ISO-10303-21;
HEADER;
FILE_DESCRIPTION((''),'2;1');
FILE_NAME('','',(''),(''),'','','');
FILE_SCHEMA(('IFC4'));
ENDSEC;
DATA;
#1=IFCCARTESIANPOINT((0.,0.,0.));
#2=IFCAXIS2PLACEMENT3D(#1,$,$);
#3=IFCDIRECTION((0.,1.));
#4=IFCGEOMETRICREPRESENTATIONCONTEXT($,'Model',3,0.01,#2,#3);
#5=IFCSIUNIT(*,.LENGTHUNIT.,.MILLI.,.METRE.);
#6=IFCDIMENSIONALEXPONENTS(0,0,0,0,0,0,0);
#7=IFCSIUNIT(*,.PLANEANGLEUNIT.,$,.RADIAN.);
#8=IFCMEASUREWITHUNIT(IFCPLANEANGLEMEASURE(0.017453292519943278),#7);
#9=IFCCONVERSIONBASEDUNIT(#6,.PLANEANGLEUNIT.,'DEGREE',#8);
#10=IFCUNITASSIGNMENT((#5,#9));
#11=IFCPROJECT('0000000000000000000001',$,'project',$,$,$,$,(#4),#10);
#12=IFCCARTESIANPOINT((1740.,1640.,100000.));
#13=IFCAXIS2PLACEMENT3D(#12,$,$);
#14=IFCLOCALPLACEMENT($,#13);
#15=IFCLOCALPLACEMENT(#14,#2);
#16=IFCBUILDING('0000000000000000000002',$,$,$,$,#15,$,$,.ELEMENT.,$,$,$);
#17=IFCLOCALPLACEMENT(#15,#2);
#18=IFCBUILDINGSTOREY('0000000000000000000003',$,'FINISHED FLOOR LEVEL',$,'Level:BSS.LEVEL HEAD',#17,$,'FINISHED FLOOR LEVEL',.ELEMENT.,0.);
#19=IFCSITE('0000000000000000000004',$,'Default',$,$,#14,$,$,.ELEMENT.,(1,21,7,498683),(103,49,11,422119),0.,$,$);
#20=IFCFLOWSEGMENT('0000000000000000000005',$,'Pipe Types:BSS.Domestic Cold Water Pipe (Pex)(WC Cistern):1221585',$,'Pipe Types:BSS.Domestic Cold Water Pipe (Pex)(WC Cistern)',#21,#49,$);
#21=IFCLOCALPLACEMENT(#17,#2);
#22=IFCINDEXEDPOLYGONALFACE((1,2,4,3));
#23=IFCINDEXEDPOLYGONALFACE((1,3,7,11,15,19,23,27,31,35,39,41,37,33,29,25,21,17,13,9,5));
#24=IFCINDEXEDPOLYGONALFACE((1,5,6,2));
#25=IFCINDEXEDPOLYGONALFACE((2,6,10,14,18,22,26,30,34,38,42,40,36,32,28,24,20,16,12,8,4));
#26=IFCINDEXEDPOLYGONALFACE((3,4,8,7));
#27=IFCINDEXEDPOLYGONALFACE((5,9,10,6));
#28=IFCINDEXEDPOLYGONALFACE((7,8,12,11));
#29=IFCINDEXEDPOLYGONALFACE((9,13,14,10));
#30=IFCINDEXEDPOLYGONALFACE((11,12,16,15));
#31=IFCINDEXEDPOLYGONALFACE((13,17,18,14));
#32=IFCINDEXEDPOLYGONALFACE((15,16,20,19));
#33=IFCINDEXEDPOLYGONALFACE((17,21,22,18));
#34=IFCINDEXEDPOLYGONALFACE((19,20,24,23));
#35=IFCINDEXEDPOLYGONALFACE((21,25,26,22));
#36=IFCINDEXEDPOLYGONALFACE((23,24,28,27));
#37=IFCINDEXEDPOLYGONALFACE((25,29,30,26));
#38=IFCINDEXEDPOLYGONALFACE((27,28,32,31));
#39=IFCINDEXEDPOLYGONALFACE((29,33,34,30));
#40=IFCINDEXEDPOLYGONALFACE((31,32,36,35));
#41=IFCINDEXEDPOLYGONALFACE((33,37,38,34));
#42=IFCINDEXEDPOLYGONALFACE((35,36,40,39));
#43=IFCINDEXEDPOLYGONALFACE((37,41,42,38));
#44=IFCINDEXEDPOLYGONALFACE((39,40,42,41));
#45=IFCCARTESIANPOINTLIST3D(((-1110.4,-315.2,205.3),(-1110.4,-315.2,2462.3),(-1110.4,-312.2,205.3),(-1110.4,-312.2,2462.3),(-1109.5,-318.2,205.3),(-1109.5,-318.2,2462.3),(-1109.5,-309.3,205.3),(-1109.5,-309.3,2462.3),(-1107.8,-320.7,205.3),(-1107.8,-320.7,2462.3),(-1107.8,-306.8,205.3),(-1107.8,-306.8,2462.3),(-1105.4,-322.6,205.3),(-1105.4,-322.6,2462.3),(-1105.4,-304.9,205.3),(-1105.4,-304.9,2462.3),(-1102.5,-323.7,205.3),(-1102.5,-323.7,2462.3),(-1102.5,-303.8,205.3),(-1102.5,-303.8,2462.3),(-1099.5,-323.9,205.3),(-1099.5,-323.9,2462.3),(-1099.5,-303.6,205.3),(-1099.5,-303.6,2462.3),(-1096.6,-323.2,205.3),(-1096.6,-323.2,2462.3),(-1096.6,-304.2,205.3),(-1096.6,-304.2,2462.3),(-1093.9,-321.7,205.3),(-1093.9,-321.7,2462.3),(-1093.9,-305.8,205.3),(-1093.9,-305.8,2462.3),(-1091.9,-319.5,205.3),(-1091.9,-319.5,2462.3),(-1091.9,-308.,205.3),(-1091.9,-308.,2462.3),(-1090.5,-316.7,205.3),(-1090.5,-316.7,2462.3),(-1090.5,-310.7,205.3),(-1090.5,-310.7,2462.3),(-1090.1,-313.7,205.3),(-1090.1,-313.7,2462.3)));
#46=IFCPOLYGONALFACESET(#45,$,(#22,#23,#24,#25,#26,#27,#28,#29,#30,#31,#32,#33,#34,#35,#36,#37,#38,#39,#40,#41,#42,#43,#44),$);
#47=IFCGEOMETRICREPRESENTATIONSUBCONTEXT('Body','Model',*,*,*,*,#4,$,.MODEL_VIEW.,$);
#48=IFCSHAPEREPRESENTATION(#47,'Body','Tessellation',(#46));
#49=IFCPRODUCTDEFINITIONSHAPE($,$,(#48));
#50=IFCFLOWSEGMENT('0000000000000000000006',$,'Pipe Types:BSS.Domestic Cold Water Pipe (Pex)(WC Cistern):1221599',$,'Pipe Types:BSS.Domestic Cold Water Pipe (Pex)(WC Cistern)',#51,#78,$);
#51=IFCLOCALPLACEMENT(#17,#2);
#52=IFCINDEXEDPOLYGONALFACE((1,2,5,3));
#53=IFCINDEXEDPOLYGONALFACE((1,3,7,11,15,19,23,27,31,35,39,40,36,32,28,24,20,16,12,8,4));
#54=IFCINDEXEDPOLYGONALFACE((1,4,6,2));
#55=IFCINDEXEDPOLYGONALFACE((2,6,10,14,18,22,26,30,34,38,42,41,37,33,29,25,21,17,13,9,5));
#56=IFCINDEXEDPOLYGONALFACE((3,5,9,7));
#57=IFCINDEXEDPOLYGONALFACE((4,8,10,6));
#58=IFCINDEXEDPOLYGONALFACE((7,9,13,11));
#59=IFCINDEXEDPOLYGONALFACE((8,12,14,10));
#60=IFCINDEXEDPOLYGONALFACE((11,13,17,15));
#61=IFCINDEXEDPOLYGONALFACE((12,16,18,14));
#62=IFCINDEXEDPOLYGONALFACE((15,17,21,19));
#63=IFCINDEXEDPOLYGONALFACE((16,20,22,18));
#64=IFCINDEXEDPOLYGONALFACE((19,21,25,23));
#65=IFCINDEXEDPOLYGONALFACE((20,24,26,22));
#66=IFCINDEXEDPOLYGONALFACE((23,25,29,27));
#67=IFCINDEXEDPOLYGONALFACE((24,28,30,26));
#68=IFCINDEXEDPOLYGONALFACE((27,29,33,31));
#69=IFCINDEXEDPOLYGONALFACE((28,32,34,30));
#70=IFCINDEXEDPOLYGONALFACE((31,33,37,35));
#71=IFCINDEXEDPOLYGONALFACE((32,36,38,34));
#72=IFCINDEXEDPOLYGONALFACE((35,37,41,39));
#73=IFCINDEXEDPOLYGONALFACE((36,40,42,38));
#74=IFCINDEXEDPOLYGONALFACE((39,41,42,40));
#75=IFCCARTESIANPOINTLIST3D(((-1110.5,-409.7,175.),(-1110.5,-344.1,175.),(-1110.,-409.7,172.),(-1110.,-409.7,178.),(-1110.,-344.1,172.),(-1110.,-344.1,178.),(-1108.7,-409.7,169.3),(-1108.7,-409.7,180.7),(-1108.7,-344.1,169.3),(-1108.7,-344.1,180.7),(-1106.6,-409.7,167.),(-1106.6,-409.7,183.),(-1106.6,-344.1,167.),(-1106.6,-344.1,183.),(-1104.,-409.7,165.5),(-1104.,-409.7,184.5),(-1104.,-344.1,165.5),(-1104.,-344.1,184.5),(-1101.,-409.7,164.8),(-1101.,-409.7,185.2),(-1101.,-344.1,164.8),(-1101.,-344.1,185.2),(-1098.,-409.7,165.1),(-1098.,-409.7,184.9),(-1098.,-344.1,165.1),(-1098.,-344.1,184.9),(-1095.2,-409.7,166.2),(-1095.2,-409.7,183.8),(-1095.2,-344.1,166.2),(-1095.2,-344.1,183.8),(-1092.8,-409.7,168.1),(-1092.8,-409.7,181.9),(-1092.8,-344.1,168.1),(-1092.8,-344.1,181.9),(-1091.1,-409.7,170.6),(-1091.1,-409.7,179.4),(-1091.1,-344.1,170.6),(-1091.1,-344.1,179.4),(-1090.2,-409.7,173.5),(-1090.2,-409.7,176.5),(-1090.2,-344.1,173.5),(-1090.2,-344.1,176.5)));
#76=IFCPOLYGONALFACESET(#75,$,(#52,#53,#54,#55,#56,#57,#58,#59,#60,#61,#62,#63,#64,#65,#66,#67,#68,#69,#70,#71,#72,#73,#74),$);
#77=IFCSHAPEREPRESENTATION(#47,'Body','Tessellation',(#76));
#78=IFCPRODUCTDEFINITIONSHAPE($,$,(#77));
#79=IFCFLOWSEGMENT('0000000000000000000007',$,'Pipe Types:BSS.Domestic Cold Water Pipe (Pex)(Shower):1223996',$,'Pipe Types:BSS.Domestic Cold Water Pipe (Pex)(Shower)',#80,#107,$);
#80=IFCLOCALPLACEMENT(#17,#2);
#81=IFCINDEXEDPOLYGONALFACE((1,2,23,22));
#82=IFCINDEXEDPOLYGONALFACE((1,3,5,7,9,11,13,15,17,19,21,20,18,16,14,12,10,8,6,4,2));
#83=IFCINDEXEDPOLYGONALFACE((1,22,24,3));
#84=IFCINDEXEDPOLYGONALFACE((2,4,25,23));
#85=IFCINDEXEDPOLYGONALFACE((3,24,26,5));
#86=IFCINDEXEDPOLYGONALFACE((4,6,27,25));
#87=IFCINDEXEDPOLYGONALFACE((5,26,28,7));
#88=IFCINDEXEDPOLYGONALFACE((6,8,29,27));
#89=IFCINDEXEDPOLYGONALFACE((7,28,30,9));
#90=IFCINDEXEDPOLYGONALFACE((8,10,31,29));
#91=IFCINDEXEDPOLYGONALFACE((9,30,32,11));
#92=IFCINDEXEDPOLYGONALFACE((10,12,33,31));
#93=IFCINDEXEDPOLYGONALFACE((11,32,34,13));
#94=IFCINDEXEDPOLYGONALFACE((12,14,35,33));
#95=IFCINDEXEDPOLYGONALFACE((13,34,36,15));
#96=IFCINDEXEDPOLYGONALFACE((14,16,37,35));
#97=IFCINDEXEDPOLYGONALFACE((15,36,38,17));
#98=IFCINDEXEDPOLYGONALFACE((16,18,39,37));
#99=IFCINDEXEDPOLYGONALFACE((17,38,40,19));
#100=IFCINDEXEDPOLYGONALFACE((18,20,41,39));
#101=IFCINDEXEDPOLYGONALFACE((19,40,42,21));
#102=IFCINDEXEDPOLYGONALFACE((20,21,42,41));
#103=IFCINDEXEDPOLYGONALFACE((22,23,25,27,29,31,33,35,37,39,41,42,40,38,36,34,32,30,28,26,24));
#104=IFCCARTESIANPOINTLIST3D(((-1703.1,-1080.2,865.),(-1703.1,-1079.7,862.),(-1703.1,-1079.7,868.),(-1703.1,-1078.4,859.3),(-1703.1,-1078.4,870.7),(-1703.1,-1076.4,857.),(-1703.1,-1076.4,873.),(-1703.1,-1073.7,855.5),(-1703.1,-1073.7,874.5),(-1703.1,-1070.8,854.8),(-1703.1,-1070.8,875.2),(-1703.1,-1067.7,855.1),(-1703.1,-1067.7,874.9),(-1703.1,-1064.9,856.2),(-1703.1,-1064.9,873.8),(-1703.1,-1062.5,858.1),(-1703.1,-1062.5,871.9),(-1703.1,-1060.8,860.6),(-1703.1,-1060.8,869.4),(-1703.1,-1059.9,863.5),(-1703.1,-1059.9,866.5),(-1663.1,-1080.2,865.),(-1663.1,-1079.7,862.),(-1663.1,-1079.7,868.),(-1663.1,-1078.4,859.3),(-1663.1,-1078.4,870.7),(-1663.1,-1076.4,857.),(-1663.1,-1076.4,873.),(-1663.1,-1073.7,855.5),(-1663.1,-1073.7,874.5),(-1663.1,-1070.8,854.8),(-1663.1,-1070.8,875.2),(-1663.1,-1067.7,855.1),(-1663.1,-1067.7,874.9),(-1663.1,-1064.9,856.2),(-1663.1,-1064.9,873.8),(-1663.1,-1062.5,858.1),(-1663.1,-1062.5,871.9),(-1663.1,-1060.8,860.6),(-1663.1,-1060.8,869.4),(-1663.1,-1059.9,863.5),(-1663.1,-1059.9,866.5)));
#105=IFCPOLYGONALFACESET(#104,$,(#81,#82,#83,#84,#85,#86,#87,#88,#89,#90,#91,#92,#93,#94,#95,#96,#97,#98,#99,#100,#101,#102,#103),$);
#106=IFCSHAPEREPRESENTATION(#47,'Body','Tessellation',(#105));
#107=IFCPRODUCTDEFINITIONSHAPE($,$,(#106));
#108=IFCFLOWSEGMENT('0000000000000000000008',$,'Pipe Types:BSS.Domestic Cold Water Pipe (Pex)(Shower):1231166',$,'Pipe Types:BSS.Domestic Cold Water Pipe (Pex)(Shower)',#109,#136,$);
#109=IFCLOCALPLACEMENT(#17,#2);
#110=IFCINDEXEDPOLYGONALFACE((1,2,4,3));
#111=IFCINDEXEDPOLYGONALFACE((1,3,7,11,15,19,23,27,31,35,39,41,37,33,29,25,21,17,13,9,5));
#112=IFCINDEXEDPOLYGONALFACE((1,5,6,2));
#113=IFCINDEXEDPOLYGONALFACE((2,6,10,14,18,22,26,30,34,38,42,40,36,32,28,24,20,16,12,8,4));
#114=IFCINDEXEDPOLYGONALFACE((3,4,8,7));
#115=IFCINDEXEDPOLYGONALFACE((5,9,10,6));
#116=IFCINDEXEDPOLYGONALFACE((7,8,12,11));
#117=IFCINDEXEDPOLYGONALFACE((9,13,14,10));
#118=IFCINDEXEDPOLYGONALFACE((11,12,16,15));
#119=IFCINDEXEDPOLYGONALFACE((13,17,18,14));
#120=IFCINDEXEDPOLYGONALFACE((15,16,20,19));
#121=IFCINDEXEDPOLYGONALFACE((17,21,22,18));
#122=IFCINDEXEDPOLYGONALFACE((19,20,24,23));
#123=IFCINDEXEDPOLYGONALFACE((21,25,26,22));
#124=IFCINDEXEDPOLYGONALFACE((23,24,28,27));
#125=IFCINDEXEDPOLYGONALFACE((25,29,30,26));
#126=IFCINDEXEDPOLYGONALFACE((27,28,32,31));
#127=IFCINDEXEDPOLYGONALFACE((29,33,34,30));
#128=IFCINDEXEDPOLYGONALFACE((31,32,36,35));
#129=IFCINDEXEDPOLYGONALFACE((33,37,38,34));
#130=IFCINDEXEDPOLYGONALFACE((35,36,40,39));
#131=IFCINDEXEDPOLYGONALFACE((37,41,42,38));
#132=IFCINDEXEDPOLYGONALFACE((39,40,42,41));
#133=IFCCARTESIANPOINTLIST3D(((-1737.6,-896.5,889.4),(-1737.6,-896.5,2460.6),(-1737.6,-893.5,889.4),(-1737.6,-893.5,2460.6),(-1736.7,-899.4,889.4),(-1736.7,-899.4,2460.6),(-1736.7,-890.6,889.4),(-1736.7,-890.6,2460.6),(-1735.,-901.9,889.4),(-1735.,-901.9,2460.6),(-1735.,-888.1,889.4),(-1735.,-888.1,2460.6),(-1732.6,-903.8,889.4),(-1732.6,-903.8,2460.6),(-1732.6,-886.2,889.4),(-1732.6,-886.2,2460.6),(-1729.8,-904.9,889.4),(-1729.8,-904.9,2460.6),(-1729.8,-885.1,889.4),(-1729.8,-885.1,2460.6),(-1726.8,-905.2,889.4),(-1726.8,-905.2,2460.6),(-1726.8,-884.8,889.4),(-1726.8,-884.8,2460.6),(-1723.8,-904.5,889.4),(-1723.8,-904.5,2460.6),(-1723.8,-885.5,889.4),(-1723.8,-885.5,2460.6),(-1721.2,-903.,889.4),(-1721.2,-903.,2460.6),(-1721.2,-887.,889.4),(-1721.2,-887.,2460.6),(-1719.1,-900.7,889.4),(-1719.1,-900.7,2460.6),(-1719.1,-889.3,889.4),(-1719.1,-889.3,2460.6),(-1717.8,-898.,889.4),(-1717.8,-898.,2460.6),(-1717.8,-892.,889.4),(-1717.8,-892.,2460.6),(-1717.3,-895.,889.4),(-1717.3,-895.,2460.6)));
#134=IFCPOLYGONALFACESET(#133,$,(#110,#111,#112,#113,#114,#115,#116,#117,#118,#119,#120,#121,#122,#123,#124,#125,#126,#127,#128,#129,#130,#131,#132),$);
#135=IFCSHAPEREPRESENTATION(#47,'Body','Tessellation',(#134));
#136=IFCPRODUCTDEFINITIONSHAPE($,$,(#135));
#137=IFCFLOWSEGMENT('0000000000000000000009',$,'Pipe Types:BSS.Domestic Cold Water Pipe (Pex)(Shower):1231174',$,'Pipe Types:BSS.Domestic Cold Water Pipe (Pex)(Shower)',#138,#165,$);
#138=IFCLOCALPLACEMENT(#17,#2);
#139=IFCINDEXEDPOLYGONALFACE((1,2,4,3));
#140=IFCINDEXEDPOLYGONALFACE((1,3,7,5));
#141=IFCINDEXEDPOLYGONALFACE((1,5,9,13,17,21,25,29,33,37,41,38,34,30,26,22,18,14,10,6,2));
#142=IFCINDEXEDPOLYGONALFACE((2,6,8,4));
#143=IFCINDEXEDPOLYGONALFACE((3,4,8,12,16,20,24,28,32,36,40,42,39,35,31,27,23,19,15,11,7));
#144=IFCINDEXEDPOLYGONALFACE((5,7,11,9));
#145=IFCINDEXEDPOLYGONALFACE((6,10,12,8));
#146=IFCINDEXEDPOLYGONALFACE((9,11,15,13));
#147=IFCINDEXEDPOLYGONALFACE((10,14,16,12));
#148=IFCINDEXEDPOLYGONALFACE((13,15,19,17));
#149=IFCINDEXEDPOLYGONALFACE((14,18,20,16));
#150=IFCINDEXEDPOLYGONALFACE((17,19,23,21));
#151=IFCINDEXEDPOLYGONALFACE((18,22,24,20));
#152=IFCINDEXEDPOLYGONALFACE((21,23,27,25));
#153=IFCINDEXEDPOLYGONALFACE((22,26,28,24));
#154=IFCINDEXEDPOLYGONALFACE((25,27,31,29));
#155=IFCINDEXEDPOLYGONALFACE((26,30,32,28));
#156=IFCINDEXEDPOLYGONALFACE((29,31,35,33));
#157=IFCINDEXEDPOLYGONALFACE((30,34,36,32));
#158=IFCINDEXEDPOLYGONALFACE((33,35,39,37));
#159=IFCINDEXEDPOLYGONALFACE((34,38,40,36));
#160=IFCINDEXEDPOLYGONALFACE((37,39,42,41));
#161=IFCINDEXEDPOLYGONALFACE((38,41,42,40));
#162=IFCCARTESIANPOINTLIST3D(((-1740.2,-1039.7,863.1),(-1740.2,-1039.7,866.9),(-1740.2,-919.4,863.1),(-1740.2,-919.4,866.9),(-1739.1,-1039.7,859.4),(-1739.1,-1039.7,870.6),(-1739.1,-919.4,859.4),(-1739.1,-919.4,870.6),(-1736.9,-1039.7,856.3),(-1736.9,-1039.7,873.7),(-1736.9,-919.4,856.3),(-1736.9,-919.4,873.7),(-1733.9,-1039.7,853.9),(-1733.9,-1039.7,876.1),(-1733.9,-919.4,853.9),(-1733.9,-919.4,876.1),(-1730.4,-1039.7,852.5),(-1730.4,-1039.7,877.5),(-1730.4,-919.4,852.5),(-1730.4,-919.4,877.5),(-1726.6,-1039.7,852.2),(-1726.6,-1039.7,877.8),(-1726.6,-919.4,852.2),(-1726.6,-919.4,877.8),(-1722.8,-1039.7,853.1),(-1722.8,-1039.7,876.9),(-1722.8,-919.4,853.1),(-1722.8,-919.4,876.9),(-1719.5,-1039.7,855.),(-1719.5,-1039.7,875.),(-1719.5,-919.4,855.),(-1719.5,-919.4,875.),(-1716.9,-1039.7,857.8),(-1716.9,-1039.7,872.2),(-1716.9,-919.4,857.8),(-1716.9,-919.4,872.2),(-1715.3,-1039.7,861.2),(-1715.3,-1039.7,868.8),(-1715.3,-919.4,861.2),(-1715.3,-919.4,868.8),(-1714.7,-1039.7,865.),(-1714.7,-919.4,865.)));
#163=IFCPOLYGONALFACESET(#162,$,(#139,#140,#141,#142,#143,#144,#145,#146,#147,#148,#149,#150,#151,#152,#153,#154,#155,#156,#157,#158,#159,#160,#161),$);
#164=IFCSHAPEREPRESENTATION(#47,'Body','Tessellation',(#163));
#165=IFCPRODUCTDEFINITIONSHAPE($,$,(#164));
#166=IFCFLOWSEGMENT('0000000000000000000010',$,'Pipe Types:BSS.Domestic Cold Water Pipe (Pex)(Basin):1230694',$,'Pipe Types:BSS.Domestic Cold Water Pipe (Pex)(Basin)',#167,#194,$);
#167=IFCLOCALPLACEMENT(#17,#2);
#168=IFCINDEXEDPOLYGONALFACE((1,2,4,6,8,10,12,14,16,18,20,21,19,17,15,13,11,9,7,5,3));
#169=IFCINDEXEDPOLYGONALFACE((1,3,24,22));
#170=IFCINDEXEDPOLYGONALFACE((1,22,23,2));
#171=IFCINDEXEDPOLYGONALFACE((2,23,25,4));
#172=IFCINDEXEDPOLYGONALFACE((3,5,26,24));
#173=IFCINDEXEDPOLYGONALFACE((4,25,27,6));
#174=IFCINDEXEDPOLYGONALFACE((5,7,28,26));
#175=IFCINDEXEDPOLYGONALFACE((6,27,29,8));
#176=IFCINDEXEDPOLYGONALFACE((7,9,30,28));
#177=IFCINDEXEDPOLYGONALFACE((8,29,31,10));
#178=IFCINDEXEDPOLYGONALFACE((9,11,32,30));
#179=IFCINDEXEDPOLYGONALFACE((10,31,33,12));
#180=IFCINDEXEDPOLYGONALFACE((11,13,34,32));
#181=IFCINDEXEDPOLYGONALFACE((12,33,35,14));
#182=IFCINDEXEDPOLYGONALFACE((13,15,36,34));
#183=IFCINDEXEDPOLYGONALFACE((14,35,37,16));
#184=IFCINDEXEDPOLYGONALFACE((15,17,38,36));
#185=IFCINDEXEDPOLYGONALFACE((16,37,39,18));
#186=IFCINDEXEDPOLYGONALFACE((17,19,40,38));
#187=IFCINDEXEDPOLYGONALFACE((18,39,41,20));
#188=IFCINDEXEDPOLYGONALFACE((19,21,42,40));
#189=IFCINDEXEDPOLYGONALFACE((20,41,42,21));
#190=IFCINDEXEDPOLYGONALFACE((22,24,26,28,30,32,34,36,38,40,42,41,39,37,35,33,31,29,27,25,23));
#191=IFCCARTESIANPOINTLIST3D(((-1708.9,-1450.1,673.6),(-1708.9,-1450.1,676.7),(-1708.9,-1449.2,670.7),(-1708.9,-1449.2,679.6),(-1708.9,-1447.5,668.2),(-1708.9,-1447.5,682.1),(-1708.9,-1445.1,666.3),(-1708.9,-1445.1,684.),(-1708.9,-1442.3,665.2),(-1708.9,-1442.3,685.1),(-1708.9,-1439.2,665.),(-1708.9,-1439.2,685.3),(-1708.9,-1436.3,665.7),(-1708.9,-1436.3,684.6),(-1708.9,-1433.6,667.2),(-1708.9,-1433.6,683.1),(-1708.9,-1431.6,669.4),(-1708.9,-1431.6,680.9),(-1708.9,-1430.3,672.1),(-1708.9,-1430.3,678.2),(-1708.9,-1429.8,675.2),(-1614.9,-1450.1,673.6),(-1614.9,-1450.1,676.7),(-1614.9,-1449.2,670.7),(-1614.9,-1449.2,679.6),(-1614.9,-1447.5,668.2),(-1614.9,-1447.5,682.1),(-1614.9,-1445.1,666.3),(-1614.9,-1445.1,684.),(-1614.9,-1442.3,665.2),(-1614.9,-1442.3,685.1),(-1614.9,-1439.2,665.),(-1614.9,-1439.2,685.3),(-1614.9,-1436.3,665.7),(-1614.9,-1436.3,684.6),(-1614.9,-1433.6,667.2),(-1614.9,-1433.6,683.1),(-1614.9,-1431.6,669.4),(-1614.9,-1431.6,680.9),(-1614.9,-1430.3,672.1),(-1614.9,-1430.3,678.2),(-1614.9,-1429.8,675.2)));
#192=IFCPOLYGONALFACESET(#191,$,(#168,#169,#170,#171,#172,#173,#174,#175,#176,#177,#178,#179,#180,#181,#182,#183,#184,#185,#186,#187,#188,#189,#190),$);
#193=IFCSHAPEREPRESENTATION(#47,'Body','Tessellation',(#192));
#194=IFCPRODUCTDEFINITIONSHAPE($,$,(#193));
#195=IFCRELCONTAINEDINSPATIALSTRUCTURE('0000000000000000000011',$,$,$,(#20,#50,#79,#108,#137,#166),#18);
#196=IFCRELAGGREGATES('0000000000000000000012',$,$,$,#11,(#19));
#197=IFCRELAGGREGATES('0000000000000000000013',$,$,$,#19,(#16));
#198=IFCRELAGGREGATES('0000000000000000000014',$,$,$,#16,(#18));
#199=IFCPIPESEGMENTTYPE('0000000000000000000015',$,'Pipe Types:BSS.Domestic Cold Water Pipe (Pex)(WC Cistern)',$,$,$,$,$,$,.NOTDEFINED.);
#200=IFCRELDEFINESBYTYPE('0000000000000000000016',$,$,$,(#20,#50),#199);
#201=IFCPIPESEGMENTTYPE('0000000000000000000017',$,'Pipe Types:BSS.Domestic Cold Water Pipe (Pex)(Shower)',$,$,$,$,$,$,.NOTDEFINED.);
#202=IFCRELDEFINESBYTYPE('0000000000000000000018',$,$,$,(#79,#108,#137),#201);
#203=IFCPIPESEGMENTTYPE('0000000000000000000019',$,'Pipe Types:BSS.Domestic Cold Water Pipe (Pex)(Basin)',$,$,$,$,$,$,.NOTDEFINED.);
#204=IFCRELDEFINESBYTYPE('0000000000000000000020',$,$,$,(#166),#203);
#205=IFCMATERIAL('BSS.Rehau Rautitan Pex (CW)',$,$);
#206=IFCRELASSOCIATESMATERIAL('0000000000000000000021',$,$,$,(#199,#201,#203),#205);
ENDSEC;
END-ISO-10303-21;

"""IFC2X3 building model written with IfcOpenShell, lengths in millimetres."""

from ifc_helpers import new_model, entity, si_unit, converted_unit, direction, frame, frame_2d, origin, origin_2d_with_axis, place, context, subcontext, project, spatial, circle, extrude, material, type_object, element, save


model = new_model("IFC2X3")

# Units and contexts
model_context = context("Model", 3, precision=0.01, world=origin(), true_north=direction((0.0, 1.0)))
body_context = subcontext(model_context, "Body", "Model", "MODEL_VIEW")
ifc_project = project(units=[si_unit("LENGTHUNIT", "METRE", prefix="MILLI"), converted_unit("PLANEANGLEUNIT", "DEGREE", entity("IfcPlaneAngleMeasure", 0.017453292519943278), si_unit("PLANEANGLEUNIT", "RADIAN"), dimensions=[0, 0, 0, 0, 0, 0, 0])], contexts=[model_context])

# Site, building, storey
site_placement = place(None, frame((1740.0, 1640.0, 100000.0)))
site = spatial("IfcSite", under=ifc_project, at=site_placement, Name="Default", CompositionType="ELEMENT", RefLatitude=(1, 21, 7, 498683), RefLongitude=(103, 49, 11, 422119), RefElevation=0.0)
building_placement = place(site_placement, origin())
building = spatial("IfcBuilding", under=site, at=building_placement, CompositionType="ELEMENT")
storey_placement = place(building_placement, origin())
storey = spatial("IfcBuildingStorey", under=building, at=storey_placement, Name="FINISHED FLOOR LEVEL", ObjectType="Level:BSS.LEVEL HEAD", LongName="FINISHED FLOOR LEVEL", CompositionType="ELEMENT", Elevation=0.0)

# Flow segments
ifc_material_1 = material(Name="BSS.Rehau Rautitan Pex (CW)")
pipe_segment_type_1 = type_object("IfcPipeSegmentType", Name="Pipe Types:BSS.Domestic Cold Water Pipe (Pex)(WC Cistern)", PredefinedType="NOTDEFINED", material=ifc_material_1)
flow_segment_1_placement = place(storey_placement, origin())
element("IfcFlowSegment", 1, at=flow_segment_1_placement, inside=storey, type_object=pipe_segment_type_1, Name="Pipe Types:BSS.Domestic Cold Water Pipe (Pex)(WC Cistern):1221585", ObjectType="Pipe Types:BSS.Domestic Cold Water Pipe (Pex)(WC Cistern)", context=body_context, shape_type="SweptSolid", body=[
    extrude(circle(Radius=10.2, at=frame_2d((0.0, 0.0), x_axis=(1.0, 0.0))), frame((-1100.3, -313.7, 205.3)), (0.0, 0.0, 1.0), 2257.0),
])
flow_segment_2_placement = place(storey_placement, origin())
element("IfcFlowSegment", 2, at=flow_segment_2_placement, inside=storey, type_object=pipe_segment_type_1, Name="Pipe Types:BSS.Domestic Cold Water Pipe (Pex)(WC Cistern):1221599", ObjectType="Pipe Types:BSS.Domestic Cold Water Pipe (Pex)(WC Cistern)", context=body_context, shape_type="SweptSolid", body=[
    extrude(circle(Radius=10.2, at=frame_2d((0.0, 0.0), x_axis=(1.0, 0.0))), frame((-1100.3, -409.7, 175.0), z_axis=(0.0, 1.0, 0.0), x_axis=(-1.0, 0.0, 0.0)), (0.0, 0.0, 1.0), 65.6),
])
pipe_segment_type_2 = type_object("IfcPipeSegmentType", Name="Pipe Types:BSS.Domestic Cold Water Pipe (Pex)(Shower)", PredefinedType="NOTDEFINED", material=ifc_material_1)
flow_segment_3_placement = place(storey_placement, origin())
element("IfcFlowSegment", 3, at=flow_segment_3_placement, inside=storey, type_object=pipe_segment_type_2, Name="Pipe Types:BSS.Domestic Cold Water Pipe (Pex)(Shower):1223996", ObjectType="Pipe Types:BSS.Domestic Cold Water Pipe (Pex)(Shower)", context=body_context, shape_type="SweptSolid", body=[
    extrude(circle(Radius=10.2, at=frame_2d((0.0, 0.0), x_axis=(1.0, 0.0))), frame((-1703.1, -1070.0, 865.0), z_axis=(1.0, 0.0, 0.0), x_axis=(0.0, -1.0, 0.0)), (0.0, 0.0, 1.0), 40.0),
])
flow_segment_4_placement = place(storey_placement, origin())
element("IfcFlowSegment", 4, at=flow_segment_4_placement, inside=storey, type_object=pipe_segment_type_2, Name="Pipe Types:BSS.Domestic Cold Water Pipe (Pex)(Shower):1231166", ObjectType="Pipe Types:BSS.Domestic Cold Water Pipe (Pex)(Shower)", context=body_context, shape_type="SweptSolid", body=[
    extrude(circle(Radius=10.2, at=frame_2d((0.0, 0.0), x_axis=(1.0, 0.0))), frame((-1727.5, -895.0, 889.4)), (0.0, 0.0, 1.0), 1571.1),
])
flow_segment_5_placement = place(storey_placement, origin())
element("IfcFlowSegment", 5, at=flow_segment_5_placement, inside=storey, type_object=pipe_segment_type_2, Name="Pipe Types:BSS.Domestic Cold Water Pipe (Pex)(Shower):1231174", ObjectType="Pipe Types:BSS.Domestic Cold Water Pipe (Pex)(Shower)", context=body_context, shape_type="SweptSolid", body=[
    extrude(circle(Radius=12.8, at=frame_2d((0.0, 0.0), x_axis=(1.0, 0.0))), frame((-1727.5, -1039.7, 865.0), z_axis=(0.0, 1.0, 0.0), x_axis=(1.0, 0.0, 0.0)), (0.0, 0.0, 1.0), 120.2),
])
pipe_segment_type_3 = type_object("IfcPipeSegmentType", Name="Pipe Types:BSS.Domestic Cold Water Pipe (Pex)(Basin)", PredefinedType="NOTDEFINED", material=ifc_material_1)
flow_segment_6_placement = place(storey_placement, origin())
element("IfcFlowSegment", 6, at=flow_segment_6_placement, inside=storey, type_object=pipe_segment_type_3, Name="Pipe Types:BSS.Domestic Cold Water Pipe (Pex)(Basin):1230694", ObjectType="Pipe Types:BSS.Domestic Cold Water Pipe (Pex)(Basin)", context=body_context, shape_type="SweptSolid", body=[
    extrude(circle(Radius=10.2, at=origin_2d_with_axis()), frame((-1708.9, -1440.0, 675.2), z_axis=(1.0, 0.0, 0.0), x_axis=(0.0, 1.0, 0.0)), (0.0, 0.0, 1.0), 94.0),
])

save(model, "model.ifc")
